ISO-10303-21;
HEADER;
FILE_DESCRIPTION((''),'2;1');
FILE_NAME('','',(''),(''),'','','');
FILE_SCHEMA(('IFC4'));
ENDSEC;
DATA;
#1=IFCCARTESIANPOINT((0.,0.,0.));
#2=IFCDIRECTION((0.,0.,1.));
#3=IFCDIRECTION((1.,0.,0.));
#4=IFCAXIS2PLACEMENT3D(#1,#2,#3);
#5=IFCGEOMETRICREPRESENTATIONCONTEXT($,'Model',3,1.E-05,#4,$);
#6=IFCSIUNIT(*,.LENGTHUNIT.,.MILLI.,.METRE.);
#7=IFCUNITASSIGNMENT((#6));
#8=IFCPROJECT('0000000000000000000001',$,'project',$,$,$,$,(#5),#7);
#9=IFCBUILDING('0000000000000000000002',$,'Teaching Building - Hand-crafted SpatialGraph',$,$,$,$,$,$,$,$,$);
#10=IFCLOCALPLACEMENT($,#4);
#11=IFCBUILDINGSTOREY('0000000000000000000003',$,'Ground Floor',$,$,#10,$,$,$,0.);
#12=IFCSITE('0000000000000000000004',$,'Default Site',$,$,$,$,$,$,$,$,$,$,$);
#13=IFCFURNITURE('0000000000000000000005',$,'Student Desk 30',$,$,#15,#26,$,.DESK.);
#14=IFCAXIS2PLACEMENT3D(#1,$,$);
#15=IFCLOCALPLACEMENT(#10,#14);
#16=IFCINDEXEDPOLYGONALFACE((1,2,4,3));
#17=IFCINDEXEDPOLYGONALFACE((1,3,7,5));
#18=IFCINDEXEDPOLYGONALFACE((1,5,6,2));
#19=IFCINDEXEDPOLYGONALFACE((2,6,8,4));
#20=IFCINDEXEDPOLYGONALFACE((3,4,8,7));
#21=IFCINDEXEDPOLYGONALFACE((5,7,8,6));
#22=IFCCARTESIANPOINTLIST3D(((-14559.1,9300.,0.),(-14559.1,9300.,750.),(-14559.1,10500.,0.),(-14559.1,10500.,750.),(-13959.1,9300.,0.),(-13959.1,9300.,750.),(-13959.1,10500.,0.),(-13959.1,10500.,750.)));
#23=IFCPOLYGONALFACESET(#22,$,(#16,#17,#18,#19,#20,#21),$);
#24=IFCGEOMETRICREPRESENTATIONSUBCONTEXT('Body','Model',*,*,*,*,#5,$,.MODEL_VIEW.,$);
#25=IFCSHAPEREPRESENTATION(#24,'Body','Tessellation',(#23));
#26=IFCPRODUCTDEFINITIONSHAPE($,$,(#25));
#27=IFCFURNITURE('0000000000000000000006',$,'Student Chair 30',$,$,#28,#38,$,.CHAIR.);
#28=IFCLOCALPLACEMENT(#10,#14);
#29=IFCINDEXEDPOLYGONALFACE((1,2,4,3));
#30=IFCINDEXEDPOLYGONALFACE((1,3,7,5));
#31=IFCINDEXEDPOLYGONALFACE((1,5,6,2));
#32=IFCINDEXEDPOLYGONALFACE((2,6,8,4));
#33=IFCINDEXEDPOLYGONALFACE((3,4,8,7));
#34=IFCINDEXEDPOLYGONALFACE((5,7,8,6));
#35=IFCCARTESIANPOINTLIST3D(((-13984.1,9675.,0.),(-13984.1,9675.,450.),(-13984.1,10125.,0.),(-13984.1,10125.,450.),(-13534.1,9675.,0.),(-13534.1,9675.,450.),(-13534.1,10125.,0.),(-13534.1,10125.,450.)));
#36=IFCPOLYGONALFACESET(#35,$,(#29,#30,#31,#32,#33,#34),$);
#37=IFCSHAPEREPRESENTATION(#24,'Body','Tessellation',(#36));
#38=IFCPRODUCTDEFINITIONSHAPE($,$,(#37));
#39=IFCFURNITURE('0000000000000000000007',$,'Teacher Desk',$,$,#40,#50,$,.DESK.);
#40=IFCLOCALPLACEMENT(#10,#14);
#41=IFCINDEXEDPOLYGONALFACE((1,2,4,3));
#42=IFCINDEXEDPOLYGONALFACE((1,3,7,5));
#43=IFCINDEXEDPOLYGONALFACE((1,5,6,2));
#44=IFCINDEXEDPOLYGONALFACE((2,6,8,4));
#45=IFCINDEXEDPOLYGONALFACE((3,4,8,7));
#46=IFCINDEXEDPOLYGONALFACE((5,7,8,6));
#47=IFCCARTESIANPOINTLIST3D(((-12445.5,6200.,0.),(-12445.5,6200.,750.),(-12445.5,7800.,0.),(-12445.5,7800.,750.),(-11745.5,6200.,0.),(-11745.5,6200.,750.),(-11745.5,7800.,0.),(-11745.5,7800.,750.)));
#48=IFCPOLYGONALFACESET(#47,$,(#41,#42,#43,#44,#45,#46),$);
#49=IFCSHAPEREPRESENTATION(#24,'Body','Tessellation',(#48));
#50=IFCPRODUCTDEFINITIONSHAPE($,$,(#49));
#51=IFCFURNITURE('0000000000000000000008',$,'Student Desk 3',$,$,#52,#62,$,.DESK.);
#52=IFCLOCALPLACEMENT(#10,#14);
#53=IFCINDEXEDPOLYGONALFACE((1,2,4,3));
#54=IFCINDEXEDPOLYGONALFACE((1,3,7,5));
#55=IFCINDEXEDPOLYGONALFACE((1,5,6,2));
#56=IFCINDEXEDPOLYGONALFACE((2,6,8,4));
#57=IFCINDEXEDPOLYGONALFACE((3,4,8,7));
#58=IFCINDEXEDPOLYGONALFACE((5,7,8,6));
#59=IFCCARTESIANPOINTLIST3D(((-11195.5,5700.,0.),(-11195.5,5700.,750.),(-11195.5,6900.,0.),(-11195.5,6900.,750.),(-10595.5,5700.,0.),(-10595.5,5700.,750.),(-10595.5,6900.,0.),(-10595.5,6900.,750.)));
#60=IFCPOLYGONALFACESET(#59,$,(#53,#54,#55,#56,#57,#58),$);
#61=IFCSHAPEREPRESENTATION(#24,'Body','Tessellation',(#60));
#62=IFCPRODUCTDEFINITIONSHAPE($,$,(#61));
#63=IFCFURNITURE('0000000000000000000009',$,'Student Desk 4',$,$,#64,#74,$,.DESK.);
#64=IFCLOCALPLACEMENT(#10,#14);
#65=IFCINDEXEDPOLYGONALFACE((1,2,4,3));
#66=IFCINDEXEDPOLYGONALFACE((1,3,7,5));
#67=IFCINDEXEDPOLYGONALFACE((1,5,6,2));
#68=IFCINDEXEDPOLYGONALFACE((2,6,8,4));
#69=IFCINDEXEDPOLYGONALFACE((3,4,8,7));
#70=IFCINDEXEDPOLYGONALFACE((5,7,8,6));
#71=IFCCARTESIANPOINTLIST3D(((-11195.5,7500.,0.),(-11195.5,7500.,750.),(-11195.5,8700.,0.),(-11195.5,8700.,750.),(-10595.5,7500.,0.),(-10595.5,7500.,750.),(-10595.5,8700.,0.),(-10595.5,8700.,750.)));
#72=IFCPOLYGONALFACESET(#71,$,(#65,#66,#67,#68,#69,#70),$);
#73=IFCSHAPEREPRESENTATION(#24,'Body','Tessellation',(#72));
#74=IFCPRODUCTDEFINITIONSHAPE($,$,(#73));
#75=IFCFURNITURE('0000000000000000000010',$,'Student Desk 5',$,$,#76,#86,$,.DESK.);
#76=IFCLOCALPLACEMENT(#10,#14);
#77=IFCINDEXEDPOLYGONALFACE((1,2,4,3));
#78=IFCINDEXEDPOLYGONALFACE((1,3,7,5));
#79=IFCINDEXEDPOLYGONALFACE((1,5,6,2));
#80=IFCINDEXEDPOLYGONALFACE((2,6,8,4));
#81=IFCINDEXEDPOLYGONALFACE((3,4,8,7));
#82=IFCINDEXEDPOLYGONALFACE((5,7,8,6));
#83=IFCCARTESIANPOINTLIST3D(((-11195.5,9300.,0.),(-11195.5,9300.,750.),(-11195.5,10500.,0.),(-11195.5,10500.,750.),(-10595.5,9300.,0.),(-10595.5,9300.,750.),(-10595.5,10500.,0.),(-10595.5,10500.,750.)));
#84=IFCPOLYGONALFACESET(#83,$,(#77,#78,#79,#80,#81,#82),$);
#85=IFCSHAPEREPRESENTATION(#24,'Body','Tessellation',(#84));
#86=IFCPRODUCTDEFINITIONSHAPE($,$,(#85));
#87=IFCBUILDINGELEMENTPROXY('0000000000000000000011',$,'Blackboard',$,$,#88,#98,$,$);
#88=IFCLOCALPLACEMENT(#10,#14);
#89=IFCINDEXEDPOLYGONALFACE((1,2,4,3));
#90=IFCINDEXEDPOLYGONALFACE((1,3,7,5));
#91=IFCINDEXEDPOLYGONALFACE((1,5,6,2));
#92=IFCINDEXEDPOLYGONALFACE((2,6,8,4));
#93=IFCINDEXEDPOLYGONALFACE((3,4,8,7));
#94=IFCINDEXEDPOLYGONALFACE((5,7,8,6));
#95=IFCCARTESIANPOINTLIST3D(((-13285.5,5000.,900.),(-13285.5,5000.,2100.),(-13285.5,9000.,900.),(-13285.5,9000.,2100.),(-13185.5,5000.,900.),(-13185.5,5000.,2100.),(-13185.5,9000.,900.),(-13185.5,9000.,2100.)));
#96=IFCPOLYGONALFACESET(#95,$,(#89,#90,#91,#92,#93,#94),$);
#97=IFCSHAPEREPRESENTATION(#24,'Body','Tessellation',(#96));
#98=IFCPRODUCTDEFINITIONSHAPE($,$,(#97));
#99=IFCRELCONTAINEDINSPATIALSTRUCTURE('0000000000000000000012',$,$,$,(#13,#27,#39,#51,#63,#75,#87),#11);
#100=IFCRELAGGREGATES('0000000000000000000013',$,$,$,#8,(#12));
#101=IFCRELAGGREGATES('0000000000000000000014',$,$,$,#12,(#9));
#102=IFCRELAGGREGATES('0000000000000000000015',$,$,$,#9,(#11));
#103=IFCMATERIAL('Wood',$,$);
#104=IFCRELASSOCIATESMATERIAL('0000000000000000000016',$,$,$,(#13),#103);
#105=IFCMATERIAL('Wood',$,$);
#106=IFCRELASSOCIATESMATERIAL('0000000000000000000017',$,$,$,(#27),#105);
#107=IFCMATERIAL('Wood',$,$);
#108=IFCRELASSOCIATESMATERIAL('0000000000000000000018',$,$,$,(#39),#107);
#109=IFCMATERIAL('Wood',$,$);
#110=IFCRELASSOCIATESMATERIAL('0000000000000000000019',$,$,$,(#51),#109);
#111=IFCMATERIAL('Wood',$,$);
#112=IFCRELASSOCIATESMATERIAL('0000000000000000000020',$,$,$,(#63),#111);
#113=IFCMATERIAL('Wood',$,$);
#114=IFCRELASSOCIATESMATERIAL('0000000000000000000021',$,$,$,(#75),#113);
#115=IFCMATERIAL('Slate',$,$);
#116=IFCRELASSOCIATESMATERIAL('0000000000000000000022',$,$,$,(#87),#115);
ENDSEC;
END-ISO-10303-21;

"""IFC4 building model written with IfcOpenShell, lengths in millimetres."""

from ifc_helpers import new_model, si_unit, frame, origin_with_axes, origin_2d, place, context, subcontext, project, spatial, rectangle, extrude, material, element, save


model = new_model("IFC4")

# Units and contexts
model_context = context("Model", 3, precision=1e-05, world=origin_with_axes())
body_context = subcontext(model_context, "Body", "Model", "MODEL_VIEW")
ifc_project = project(units=[si_unit("LENGTHUNIT", "METRE", prefix="MILLI")], contexts=[model_context])

# Site, building, storey
site = spatial("IfcSite", under=ifc_project, Name="Default Site")
building = spatial("IfcBuilding", under=site, Name="Teaching Building - Hand-crafted SpatialGraph")
storey_placement = place(None, origin_with_axes())
storey = spatial("IfcBuildingStorey", under=building, at=storey_placement, Name="Ground Floor", Elevation=0.0)

# Furniture
ifc_material_1 = material(Name="Wood")
furniture_1_placement = place(storey_placement, frame((-14259.1, 9900.0, 0.0), z_axis=(0.0, 0.0, 1.0), x_axis=(0.0, 1.0, 0.0)))
element("IfcFurniture", 1, at=furniture_1_placement, inside=storey, material=ifc_material_1, Name="Student Desk 30", PredefinedType="DESK", context=body_context, shape_type="SweptSolid", body=[
    extrude(rectangle(XDim=1200.0, YDim=600.0, at=origin_2d()), origin_with_axes(), (0.0, 0.0, 1.0), 750.0),
])
ifc_material_2 = material(Name="Wood")
furniture_2_placement = place(storey_placement, frame((-13759.1, 9900.0, 0.0), z_axis=(0.0, 0.0, 1.0), x_axis=(1.0, 0.0, 0.0)))
element("IfcFurniture", 2, at=furniture_2_placement, inside=storey, material=ifc_material_2, Name="Student Chair 30", PredefinedType="CHAIR", context=body_context, shape_type="SweptSolid", body=[
    extrude(rectangle(XDim=450.0, YDim=450.0, at=origin_2d()), origin_with_axes(), (0.0, 0.0, 1.0), 450.0),
])
ifc_material_3 = material(Name="Wood")
furniture_3_placement = place(storey_placement, frame((-12095.5, 7000.0, 0.0), z_axis=(0.0, 0.0, 1.0), x_axis=(0.0, 1.0, 0.0)))
element("IfcFurniture", 3, at=furniture_3_placement, inside=storey, material=ifc_material_3, Name="Teacher Desk", PredefinedType="DESK", context=body_context, shape_type="SweptSolid", body=[
    extrude(rectangle(XDim=1600.0, YDim=700.0, at=origin_2d()), origin_with_axes(), (0.0, 0.0, 1.0), 750.0),
])
ifc_material_4 = material(Name="Wood")
furniture_4_placement = place(storey_placement, frame((-10895.5, 6300.0, 0.0), z_axis=(0.0, 0.0, 1.0), x_axis=(0.0, 1.0, 0.0)))
element("IfcFurniture", 4, at=furniture_4_placement, inside=storey, material=ifc_material_4, Name="Student Desk 3", PredefinedType="DESK", context=body_context, shape_type="SweptSolid", body=[
    extrude(rectangle(XDim=1200.0, YDim=600.0, at=origin_2d()), origin_with_axes(), (0.0, 0.0, 1.0), 750.0),
])
ifc_material_5 = material(Name="Wood")
furniture_5_placement = place(storey_placement, frame((-10895.5, 8100.0, 0.0), z_axis=(0.0, 0.0, 1.0), x_axis=(0.0, 1.0, 0.0)))
element("IfcFurniture", 5, at=furniture_5_placement, inside=storey, material=ifc_material_5, Name="Student Desk 4", PredefinedType="DESK", context=body_context, shape_type="SweptSolid", body=[
    extrude(rectangle(XDim=1200.0, YDim=600.0, at=origin_2d()), origin_with_axes(), (0.0, 0.0, 1.0), 750.0),
])
ifc_material_6 = material(Name="Wood")
furniture_6_placement = place(storey_placement, frame((-10895.5, 9900.0, 0.0), z_axis=(0.0, 0.0, 1.0), x_axis=(0.0, 1.0, 0.0)))
element("IfcFurniture", 6, at=furniture_6_placement, inside=storey, material=ifc_material_6, Name="Student Desk 5", PredefinedType="DESK", context=body_context, shape_type="SweptSolid", body=[
    extrude(rectangle(XDim=1200.0, YDim=600.0, at=origin_2d()), origin_with_axes(), (0.0, 0.0, 1.0), 750.0),
])

# Building element proxy
ifc_material_7 = material(Name="Slate")
proxy_placement = place(storey_placement, frame((-13235.5, 7000.0, 900.0), z_axis=(0.0, 0.0, 1.0), x_axis=(1.0, 0.0, 0.0)))
element("IfcBuildingElementProxy", 7, at=proxy_placement, inside=storey, material=ifc_material_7, Name="Blackboard", context=body_context, shape_type="SweptSolid", body=[
    extrude(rectangle(XDim=100.0, YDim=4000.0, at=origin_2d()), origin_with_axes(), (0.0, 0.0, 1.0), 1200.0),
])

save(model, "model.ifc")
